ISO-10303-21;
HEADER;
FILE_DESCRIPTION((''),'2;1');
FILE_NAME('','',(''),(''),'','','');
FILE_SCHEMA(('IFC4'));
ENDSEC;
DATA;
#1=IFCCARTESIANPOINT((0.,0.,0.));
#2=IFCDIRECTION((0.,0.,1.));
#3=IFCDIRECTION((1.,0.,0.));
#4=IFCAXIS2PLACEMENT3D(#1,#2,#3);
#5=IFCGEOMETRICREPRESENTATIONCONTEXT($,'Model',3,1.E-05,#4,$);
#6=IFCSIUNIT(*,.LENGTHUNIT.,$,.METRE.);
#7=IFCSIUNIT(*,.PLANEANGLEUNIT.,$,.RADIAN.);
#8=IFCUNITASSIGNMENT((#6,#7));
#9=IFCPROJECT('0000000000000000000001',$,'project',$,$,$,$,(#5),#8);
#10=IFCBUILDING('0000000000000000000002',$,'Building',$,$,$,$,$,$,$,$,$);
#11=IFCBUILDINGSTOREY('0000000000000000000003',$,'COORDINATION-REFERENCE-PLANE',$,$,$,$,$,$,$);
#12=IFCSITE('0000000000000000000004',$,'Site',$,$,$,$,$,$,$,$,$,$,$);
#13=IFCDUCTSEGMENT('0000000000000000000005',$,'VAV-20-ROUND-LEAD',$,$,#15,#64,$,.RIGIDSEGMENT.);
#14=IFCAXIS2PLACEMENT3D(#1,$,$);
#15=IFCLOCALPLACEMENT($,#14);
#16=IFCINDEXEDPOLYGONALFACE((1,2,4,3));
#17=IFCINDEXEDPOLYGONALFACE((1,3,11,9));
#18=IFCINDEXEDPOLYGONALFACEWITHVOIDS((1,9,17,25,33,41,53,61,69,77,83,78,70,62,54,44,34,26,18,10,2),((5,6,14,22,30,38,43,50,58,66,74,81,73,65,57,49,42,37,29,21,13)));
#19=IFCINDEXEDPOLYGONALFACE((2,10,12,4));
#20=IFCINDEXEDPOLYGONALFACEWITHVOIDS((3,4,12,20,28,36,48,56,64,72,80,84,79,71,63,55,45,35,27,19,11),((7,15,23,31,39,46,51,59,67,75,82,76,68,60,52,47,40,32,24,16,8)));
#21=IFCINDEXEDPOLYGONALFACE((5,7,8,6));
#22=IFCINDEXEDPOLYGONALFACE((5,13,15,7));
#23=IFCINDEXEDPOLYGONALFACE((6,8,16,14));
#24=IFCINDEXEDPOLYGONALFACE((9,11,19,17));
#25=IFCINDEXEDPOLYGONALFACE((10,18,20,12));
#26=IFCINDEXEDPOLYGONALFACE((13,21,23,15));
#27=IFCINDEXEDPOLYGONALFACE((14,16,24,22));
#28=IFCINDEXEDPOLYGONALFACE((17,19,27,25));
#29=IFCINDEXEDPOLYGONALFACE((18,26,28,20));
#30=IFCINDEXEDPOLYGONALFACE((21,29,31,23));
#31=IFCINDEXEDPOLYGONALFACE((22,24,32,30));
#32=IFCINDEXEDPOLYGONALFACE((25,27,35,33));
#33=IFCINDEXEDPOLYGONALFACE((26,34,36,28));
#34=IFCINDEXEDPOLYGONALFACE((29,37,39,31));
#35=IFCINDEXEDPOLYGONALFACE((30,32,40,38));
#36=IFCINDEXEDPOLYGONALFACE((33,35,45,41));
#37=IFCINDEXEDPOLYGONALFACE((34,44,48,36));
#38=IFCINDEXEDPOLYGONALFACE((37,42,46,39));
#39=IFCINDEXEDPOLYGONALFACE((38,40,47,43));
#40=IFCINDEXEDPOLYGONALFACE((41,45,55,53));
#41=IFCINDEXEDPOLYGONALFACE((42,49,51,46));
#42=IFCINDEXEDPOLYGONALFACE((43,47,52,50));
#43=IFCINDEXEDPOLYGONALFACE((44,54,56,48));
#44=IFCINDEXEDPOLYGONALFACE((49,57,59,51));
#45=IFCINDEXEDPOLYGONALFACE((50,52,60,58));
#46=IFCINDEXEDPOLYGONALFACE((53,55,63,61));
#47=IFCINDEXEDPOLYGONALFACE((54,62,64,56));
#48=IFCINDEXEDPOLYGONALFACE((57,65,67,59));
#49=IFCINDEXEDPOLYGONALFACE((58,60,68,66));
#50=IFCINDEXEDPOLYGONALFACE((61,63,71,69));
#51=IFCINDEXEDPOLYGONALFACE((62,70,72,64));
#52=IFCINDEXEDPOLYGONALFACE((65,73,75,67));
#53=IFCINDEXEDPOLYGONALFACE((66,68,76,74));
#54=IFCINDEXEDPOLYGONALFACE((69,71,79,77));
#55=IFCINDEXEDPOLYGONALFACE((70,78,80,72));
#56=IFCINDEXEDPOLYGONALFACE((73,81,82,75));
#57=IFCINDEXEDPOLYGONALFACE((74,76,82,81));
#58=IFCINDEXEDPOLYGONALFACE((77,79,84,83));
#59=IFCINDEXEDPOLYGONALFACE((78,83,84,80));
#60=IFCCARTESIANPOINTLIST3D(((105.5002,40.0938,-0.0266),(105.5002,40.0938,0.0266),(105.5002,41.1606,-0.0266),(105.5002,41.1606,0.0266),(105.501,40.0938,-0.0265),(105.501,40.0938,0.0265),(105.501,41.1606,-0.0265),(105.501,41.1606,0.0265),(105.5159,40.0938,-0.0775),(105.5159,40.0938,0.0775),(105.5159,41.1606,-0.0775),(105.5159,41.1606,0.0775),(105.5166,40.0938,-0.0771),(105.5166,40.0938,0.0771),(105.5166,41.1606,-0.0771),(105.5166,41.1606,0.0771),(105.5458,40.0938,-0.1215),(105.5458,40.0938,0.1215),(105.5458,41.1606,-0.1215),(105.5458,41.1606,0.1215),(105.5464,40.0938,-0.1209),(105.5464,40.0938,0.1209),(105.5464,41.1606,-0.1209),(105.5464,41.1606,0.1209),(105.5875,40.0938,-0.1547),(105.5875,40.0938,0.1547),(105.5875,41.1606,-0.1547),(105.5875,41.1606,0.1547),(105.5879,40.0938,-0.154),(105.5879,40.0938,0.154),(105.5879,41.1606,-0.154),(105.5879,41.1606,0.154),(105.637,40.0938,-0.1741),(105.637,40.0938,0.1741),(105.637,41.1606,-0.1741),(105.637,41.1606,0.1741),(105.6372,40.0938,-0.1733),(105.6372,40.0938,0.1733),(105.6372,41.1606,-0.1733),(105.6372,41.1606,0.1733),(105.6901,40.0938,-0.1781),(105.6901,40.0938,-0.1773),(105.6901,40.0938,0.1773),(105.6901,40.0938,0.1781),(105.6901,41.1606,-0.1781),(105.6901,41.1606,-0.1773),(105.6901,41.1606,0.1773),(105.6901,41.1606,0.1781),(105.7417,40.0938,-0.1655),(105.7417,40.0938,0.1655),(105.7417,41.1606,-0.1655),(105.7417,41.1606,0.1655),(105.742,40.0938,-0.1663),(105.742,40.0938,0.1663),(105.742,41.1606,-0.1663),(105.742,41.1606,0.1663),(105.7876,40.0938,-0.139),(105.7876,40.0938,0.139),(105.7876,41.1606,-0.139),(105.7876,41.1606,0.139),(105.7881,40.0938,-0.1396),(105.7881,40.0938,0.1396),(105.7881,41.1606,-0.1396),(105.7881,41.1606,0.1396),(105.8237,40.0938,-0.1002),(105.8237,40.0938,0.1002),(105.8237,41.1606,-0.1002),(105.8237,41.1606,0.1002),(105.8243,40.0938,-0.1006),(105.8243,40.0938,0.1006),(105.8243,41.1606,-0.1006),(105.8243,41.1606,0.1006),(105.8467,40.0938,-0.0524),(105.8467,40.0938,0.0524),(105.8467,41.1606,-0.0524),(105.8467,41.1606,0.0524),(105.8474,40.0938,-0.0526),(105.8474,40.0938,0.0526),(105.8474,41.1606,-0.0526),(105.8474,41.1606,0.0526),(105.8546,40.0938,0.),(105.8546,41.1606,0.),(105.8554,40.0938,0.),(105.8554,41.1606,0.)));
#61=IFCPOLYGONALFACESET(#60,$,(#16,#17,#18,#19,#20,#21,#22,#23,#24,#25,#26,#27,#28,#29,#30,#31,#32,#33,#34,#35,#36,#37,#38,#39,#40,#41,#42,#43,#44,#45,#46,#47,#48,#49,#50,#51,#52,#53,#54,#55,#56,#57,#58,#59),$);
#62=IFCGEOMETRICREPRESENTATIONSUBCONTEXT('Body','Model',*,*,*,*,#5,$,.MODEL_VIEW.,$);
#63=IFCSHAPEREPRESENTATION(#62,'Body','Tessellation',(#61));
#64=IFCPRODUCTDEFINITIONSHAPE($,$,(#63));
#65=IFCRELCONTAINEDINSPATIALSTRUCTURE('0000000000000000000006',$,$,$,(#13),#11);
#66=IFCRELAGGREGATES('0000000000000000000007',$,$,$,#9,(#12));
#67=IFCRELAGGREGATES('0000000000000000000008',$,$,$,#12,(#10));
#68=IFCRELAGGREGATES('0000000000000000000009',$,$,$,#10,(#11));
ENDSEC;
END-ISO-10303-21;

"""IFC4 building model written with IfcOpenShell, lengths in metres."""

from ifc_helpers import new_model, si_unit, frame, origin, origin_with_axes, place, context, subcontext, project, spatial, hollow_circle, extrude, element, save


model = new_model("IFC4")

# Units and contexts
model_context = context("Model", 3, precision=1e-05, world=origin_with_axes())
body_context_1 = subcontext(model_context, "Body", "Model", "MODEL_VIEW")
ifc_project = project(units=[si_unit("LENGTHUNIT", "METRE"), si_unit("PLANEANGLEUNIT", "RADIAN")], contexts=[model_context])

# Site, building, storey
site = spatial("IfcSite", under=ifc_project, Name="Site")
building = spatial("IfcBuilding", under=site, Name="Building")
storey = spatial("IfcBuildingStorey", under=building, Name="COORDINATION-REFERENCE-PLANE")

# Duct segment
duct_segment_1_placement = place(None, frame((105.6768, 40.0938, 0.0), z_axis=(0.0, 1.0, 0.0), x_axis=(1.0, 0.0, 0.0)))
element("IfcDuctSegment", 1, at=duct_segment_1_placement, inside=storey, Name="VAV-20-ROUND-LEAD", PredefinedType="RIGIDSEGMENT", context=body_context_1, shape_type="SweptSolid", body=[
    extrude(hollow_circle(Radius=0.1786, WallThickness=0.0008), origin(), (0.0, 0.0, 1.0), 1.0668),
])

save(model, "model.ifc")
